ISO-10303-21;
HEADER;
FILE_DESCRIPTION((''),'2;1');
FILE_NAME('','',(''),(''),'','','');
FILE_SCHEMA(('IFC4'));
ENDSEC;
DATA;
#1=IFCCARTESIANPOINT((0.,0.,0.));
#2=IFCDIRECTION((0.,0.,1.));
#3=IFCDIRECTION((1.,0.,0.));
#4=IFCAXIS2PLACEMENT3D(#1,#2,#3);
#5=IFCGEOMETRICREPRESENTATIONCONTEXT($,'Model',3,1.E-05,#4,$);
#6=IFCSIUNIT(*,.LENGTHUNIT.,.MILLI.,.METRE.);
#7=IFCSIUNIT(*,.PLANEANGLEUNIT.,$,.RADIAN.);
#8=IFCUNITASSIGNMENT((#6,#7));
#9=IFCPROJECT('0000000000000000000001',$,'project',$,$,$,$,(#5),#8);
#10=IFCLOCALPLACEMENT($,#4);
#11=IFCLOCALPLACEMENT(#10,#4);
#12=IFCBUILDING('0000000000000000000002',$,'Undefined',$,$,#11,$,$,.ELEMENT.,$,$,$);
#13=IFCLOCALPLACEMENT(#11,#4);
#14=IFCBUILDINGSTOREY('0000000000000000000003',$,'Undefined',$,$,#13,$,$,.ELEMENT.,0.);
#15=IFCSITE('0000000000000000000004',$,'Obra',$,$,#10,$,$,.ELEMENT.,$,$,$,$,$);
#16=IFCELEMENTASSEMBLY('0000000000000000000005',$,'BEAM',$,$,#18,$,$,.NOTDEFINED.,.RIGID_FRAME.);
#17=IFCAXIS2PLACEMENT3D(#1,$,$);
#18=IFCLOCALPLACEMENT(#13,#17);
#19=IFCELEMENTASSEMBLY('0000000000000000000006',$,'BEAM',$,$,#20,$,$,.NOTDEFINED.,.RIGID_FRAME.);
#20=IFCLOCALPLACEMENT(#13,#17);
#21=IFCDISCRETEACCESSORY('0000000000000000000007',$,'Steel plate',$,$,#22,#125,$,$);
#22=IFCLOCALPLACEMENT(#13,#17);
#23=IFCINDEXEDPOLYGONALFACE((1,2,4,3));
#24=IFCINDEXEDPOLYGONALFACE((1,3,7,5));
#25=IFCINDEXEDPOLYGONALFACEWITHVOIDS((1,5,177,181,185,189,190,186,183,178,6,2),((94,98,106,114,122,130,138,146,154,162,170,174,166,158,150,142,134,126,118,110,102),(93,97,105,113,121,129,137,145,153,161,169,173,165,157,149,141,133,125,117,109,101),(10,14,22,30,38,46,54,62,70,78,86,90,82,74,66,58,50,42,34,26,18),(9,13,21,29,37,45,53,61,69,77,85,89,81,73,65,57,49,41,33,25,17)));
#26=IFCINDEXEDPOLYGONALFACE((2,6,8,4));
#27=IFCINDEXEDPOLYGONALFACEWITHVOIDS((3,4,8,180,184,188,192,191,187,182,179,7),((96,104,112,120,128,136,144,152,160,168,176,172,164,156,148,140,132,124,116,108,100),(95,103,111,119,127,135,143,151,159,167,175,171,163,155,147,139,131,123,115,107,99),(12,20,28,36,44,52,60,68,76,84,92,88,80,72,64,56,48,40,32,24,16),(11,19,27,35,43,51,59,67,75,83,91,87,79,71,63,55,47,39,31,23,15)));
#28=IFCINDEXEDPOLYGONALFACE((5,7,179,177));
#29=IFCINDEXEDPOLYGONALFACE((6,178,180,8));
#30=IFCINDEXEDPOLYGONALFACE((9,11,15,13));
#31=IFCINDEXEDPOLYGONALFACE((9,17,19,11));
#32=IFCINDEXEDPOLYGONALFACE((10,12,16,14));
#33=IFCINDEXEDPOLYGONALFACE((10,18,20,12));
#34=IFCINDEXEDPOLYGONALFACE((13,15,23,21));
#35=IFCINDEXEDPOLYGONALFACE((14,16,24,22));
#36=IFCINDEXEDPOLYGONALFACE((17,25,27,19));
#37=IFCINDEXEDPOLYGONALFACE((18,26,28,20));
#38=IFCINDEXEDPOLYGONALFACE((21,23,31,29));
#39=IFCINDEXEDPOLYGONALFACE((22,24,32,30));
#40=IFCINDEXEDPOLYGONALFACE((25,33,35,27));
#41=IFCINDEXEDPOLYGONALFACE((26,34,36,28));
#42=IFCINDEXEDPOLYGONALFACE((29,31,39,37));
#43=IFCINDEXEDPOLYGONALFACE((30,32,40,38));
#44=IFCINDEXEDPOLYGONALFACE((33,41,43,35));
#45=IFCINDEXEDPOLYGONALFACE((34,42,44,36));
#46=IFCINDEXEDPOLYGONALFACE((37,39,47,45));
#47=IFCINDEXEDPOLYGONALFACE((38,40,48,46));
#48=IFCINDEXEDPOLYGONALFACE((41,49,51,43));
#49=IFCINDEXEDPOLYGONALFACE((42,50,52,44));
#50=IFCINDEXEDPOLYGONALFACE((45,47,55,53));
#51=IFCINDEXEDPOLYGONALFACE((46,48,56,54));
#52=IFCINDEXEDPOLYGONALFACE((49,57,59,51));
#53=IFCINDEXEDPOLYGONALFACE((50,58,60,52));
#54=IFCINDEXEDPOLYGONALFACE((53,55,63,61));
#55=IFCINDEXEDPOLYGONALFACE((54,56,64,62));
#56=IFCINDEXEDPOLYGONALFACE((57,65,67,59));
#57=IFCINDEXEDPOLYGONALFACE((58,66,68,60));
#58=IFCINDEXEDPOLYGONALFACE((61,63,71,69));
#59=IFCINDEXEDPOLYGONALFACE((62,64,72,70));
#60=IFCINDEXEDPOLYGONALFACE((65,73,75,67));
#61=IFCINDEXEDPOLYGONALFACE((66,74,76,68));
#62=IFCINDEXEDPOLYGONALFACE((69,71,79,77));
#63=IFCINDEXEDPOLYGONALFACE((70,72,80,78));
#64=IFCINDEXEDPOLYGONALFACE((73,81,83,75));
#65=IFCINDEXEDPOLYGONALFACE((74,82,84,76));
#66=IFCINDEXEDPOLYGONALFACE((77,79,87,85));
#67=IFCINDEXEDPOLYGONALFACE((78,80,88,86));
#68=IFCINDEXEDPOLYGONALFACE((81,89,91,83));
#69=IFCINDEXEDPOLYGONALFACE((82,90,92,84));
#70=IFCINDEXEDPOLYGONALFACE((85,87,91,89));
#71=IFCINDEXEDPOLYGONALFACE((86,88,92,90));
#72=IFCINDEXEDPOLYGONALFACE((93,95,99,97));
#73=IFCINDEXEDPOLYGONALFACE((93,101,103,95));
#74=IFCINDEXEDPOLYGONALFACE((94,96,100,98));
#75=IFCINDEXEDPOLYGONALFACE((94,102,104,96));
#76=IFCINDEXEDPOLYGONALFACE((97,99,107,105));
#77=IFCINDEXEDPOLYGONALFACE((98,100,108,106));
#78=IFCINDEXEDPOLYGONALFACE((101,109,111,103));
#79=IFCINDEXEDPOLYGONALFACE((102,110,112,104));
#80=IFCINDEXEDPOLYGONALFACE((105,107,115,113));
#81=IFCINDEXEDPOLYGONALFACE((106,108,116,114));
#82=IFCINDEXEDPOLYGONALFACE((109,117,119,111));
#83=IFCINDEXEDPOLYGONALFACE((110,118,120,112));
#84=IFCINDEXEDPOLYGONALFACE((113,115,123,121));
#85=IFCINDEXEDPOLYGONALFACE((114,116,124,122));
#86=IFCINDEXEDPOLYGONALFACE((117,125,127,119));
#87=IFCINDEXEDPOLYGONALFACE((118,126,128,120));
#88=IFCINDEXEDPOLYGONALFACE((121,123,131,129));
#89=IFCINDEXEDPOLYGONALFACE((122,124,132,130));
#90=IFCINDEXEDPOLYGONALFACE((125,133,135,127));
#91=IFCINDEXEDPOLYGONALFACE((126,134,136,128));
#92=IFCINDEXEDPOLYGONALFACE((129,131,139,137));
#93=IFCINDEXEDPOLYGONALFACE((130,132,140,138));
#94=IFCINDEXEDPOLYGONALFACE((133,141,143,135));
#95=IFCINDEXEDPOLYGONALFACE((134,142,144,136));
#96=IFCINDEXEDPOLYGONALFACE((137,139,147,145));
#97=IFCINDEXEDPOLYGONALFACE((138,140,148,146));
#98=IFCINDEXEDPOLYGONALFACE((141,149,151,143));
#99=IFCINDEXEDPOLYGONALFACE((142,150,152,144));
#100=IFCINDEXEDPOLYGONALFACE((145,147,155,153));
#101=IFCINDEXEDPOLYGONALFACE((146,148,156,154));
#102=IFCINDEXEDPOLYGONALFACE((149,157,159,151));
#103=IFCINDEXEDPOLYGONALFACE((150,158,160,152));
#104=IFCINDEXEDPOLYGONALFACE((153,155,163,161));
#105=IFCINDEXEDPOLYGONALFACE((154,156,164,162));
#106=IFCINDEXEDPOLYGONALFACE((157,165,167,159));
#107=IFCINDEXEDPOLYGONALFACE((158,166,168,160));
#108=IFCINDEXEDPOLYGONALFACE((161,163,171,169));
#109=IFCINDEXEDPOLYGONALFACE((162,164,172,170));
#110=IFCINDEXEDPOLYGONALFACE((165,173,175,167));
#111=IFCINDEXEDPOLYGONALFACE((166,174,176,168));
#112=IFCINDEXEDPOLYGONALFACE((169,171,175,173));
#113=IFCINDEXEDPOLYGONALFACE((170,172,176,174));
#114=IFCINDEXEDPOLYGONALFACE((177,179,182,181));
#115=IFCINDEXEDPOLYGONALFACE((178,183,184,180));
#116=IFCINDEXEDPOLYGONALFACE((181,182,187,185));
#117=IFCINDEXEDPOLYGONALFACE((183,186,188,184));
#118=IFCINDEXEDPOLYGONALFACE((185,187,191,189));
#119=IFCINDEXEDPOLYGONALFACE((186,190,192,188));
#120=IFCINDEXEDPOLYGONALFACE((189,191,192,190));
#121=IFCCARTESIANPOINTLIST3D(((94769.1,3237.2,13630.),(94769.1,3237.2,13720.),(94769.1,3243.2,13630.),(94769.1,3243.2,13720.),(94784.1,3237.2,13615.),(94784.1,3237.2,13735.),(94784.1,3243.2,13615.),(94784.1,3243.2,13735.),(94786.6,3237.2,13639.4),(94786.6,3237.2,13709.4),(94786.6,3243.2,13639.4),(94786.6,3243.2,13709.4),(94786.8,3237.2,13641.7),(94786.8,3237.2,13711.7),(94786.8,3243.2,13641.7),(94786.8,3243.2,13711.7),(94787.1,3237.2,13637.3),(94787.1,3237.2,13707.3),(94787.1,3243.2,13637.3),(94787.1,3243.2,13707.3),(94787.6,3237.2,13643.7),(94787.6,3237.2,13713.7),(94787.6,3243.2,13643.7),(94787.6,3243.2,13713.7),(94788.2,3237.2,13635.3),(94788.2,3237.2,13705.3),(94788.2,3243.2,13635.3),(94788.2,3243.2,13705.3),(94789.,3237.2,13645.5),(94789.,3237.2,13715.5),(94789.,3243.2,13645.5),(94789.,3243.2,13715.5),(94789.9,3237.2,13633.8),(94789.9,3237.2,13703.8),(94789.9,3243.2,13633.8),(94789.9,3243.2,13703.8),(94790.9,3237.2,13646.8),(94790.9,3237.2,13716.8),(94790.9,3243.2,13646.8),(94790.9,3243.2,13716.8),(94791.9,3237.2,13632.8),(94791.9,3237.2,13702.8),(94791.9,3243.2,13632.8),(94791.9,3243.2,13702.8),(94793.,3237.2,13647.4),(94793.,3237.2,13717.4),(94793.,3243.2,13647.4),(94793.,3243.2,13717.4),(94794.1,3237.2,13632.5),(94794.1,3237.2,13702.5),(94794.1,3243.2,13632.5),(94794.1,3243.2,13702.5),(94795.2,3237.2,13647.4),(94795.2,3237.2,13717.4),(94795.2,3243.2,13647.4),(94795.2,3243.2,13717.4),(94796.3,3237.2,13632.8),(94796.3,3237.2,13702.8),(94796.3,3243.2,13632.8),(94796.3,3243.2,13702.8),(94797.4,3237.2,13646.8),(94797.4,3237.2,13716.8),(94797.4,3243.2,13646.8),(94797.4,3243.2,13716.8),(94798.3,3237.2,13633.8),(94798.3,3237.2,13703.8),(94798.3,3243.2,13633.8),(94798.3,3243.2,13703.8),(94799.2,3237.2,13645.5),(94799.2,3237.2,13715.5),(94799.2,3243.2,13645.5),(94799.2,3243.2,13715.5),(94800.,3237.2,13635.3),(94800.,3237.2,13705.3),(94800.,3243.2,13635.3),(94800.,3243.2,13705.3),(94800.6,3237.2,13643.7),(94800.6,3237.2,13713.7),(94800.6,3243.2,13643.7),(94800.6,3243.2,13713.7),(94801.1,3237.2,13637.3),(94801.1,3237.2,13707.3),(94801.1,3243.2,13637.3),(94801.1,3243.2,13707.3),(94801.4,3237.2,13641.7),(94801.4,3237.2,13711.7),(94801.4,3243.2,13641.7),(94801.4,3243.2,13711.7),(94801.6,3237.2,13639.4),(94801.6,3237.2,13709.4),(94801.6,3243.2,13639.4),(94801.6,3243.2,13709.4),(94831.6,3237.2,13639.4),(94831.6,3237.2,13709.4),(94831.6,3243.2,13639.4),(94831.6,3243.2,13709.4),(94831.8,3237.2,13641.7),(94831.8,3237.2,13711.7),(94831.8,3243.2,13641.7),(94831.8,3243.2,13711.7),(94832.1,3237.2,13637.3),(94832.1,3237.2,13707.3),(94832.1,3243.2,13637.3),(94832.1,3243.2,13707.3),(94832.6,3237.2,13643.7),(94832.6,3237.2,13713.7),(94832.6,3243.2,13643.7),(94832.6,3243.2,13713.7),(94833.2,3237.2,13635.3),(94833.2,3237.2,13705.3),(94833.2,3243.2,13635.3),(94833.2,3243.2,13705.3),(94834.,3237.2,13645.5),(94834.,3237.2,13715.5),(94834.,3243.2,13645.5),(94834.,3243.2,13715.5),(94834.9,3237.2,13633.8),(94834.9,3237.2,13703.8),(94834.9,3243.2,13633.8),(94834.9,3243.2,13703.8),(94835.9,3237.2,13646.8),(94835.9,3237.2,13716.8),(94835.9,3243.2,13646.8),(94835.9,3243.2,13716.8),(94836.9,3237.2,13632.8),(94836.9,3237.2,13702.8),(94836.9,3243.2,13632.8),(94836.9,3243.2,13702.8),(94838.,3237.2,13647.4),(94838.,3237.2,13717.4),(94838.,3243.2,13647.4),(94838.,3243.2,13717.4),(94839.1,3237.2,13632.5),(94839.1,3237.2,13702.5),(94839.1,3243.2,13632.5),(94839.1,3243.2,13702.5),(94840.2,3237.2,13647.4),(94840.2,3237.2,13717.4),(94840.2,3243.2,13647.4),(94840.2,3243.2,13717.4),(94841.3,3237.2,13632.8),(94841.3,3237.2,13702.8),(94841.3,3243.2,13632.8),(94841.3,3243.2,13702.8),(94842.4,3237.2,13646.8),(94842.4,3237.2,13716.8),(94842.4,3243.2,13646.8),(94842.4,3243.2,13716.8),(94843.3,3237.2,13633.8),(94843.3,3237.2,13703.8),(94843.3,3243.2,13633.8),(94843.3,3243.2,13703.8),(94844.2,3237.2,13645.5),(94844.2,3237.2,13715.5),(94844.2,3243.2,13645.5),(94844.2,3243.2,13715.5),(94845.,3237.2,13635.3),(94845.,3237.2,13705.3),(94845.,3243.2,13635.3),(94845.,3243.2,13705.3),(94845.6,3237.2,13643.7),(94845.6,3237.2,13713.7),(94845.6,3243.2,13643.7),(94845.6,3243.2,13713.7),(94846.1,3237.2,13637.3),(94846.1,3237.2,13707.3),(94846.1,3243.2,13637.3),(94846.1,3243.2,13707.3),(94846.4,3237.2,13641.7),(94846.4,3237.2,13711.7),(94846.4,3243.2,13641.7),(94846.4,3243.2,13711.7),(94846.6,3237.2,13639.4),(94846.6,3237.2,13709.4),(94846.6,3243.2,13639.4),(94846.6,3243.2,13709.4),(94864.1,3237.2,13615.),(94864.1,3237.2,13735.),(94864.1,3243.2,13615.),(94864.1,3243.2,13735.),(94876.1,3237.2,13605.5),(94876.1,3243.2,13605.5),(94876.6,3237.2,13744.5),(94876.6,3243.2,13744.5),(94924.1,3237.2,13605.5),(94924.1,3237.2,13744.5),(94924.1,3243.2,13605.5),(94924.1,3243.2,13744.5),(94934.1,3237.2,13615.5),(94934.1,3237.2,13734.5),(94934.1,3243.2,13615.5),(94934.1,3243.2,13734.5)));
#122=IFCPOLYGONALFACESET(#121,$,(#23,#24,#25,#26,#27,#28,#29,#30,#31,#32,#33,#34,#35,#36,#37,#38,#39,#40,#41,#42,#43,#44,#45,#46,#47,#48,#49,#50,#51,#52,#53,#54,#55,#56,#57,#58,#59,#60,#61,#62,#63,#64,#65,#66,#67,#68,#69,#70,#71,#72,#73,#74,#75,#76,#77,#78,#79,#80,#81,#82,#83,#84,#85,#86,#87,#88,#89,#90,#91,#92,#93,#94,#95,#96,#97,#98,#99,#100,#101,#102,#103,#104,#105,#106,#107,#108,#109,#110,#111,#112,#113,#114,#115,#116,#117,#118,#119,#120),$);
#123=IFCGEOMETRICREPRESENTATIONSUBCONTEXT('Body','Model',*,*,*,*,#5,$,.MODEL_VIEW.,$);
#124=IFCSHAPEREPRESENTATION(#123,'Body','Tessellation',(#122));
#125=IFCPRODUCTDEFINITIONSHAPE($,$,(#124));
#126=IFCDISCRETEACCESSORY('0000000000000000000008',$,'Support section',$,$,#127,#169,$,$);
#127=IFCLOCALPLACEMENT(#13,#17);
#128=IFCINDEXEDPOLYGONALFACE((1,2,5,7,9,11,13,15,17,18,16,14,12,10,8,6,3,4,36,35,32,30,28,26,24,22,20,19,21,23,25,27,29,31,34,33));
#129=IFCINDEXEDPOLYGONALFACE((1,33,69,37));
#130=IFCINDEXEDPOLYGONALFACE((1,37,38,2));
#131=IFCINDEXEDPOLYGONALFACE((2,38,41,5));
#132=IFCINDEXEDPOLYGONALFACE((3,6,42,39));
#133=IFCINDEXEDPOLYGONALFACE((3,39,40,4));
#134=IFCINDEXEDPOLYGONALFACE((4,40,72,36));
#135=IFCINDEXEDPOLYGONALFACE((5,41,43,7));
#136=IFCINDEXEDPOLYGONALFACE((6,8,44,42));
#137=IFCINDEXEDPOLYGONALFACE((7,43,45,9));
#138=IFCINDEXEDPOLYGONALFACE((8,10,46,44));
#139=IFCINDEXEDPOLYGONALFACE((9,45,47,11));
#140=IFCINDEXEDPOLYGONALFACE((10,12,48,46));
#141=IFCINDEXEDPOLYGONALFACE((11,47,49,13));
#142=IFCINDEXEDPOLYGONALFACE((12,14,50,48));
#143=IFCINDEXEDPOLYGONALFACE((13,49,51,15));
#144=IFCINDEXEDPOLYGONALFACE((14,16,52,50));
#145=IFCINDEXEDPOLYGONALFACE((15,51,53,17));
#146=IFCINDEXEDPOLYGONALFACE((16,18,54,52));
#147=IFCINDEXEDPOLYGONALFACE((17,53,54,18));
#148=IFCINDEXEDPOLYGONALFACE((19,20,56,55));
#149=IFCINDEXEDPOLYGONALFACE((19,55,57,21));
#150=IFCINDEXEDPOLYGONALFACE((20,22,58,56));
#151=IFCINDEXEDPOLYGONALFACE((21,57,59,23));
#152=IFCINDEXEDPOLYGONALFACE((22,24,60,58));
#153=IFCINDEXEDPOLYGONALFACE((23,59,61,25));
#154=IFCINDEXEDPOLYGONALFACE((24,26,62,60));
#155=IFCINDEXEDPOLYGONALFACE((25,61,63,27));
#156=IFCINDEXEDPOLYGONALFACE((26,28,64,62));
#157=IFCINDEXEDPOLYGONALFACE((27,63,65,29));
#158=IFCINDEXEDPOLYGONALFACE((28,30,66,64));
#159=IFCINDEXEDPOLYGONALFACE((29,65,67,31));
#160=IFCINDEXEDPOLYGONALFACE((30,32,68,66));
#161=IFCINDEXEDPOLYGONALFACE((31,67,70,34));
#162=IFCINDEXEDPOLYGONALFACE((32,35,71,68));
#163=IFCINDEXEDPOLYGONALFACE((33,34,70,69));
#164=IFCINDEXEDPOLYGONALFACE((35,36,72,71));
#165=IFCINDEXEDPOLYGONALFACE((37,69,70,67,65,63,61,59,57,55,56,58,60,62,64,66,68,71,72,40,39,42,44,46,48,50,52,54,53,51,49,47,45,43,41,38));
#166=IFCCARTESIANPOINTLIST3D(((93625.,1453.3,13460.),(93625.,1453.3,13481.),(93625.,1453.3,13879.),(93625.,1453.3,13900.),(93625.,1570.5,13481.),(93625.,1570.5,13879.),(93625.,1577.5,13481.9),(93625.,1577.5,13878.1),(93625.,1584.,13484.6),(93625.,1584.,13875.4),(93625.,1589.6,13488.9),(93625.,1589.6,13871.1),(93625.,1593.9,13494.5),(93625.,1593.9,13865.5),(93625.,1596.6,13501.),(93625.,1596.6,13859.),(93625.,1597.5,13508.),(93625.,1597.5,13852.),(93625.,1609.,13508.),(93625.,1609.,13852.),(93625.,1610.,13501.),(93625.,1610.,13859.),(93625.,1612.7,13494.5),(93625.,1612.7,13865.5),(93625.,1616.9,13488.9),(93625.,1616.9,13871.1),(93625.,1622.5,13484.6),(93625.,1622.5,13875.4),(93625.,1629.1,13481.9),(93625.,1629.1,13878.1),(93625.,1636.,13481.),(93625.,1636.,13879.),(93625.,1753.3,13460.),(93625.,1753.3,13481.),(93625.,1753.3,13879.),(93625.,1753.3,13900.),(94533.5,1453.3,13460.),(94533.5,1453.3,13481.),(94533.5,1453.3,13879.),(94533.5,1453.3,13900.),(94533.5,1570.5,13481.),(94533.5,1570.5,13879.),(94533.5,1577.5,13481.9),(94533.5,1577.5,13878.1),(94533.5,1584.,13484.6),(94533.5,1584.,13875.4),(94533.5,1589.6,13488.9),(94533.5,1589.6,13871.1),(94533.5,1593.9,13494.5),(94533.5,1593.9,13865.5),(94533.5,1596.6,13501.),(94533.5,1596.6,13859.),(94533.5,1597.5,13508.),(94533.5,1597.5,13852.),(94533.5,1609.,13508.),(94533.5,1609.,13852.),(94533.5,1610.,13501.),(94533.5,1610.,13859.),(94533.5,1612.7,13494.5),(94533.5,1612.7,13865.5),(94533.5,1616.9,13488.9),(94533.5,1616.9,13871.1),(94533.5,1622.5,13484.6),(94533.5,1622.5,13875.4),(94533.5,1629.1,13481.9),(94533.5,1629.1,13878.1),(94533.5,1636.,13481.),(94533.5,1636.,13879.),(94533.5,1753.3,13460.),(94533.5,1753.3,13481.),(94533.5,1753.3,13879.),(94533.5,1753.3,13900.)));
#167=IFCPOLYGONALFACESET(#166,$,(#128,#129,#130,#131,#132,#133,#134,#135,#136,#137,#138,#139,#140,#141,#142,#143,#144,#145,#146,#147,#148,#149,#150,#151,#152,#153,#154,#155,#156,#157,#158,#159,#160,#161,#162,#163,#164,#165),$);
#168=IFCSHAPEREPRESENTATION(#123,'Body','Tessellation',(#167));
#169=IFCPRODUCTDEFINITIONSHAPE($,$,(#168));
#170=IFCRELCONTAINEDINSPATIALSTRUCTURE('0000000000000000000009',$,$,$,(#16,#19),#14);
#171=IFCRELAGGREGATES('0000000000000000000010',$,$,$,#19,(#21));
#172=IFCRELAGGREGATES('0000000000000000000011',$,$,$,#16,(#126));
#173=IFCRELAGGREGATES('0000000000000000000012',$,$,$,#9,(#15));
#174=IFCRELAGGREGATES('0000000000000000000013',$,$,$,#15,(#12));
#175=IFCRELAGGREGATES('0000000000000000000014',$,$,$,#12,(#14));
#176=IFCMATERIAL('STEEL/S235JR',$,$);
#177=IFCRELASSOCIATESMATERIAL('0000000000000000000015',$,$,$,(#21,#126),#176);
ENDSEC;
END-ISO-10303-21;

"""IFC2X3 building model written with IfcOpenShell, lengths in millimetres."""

from ifc_helpers import new_model, si_unit, frame, origin_with_axes, origin_2d_with_axis, place, context, subcontext, project, spatial, polyline, circle, i_section, outline, extrude, source, transform, mapped, material, element, aggregate, save


model = new_model("IFC2X3")

# Units and contexts
model_context = context("Model", 3, precision=1e-05, world=origin_with_axes())
body_context = subcontext(model_context, "Body", "Model", "MODEL_VIEW")
ifc_project = project(units=[si_unit("LENGTHUNIT", "METRE", prefix="MILLI"), si_unit("PLANEANGLEUNIT", "RADIAN")], contexts=[model_context])

# Site, building, storey
site_placement = place(None, origin_with_axes())
site = spatial("IfcSite", under=ifc_project, at=site_placement, Name="Obra", CompositionType="ELEMENT")
building_placement = place(site_placement, origin_with_axes())
building = spatial("IfcBuilding", under=site, at=building_placement, Name="Undefined", CompositionType="ELEMENT")
storey_placement = place(building_placement, origin_with_axes())
storey = spatial("IfcBuildingStorey", under=building, at=storey_placement, Name="Undefined", CompositionType="ELEMENT", Elevation=0.0)

# Shared definitions
ifc_material_1 = material(Name="STEEL/S235JR")

# Element assembly
assembly_1_placement = place(storey_placement, origin_with_axes())
assembly_1 = element("IfcElementAssembly", 1, at=assembly_1_placement, inside=storey, Name="BEAM", AssemblyPlace="NOTDEFINED", PredefinedType="RIGID_FRAME")

# Element assembly
assembly_2_placement = place(storey_placement, origin_with_axes())
assembly_2 = element("IfcElementAssembly", 2, at=assembly_2_placement, inside=storey, Name="BEAM", AssemblyPlace="NOTDEFINED", PredefinedType="RIGID_FRAME")

# Discrete accessory, opening
shared_shape_1 = source(origin_with_axes(), body_context, "Body", "SweptSolid", [
    extrude(circle(Radius=7.5, at=origin_2d_with_axis()), frame((0.0, 2.4, 0.0), z_axis=(0.0, 1.0, 0.0), x_axis=(1.0, 0.0, 0.0)), (0.0, 0.0, 1.0), 6.2),
])
discrete_accessory_1_placement = place(assembly_2_placement, frame((94934.1, 3240.2, 13615.5), z_axis=(0.0, 1.0, 0.0), x_axis=(-0.707107, 0.0, -0.707107)))
discrete_accessory_1 = element("IfcDiscreteAccessory", 3, at=discrete_accessory_1_placement, material=ifc_material_1, Name="Steel plate", context=body_context, shape_type="SweptSolid", body=[
    extrude(outline(polyline([(0.0, 0.0), (14.1, 0.0), (48.1, 33.9), (49.9, 49.1), (106.4, 105.7), (106.4, 126.9), (42.8, 190.6), (21.6, 190.6), (-35.0, 134.0), (-50.6, 131.9), (-84.1, 98.3), (-84.1, 84.1), (0.0, 0.0)])), frame((0.0, 0.0, -3.0), z_axis=(0.0, 0.0, 1.0), x_axis=(1.0, 0.0, 0.0)), (0.0, 0.0, 1.0), 6.0),
])
opening_1_placement = place(assembly_2_placement, frame((94816.6, 3245.7, 13710.0), z_axis=(-1.0, 0.0, 0.0), x_axis=(0.0, 0.0, -1.0)))
element("IfcOpeningElement", 4, at=opening_1_placement, cuts=discrete_accessory_1, ObjectType="Opening", context=body_context, shape_type="MappedRepresentation", body=[
    mapped(shared_shape_1, transform((0.0, 0.0, -22.5))),
    mapped(shared_shape_1, transform((70.0, 0.0, -22.5))),
    mapped(shared_shape_1, transform((0.0, 0.0, 22.5))),
    mapped(shared_shape_1, transform((70.0, 0.0, 22.5))),
])

# Discrete accessory
discrete_accessory_2_placement = place(assembly_1_placement, frame((93625.0, 1603.3, 13680.0), z_axis=(0.0, 0.0, 1.0), x_axis=(1.0, 0.0, 0.0)))
discrete_accessory_2 = element("IfcDiscreteAccessory", 5, at=discrete_accessory_2_placement, material=ifc_material_1, Name="Support section", context=body_context, shape_type="SweptSolid", body=[
    extrude(i_section(OverallWidth=300.0, OverallDepth=440.0, WebThickness=11.5, FlangeThickness=21.0, FilletRadius=27.0, at=origin_2d_with_axis()), frame((908.5, 0.0, 0.0), z_axis=(-1.0, 0.0, 0.0), x_axis=(0.0, -1.0, 0.0)), (0.0, 0.0, 1.0), 908.5),
])

aggregate(assembly_2, [discrete_accessory_1])

aggregate(assembly_1, [discrete_accessory_2])

save(model, "model.ifc")
